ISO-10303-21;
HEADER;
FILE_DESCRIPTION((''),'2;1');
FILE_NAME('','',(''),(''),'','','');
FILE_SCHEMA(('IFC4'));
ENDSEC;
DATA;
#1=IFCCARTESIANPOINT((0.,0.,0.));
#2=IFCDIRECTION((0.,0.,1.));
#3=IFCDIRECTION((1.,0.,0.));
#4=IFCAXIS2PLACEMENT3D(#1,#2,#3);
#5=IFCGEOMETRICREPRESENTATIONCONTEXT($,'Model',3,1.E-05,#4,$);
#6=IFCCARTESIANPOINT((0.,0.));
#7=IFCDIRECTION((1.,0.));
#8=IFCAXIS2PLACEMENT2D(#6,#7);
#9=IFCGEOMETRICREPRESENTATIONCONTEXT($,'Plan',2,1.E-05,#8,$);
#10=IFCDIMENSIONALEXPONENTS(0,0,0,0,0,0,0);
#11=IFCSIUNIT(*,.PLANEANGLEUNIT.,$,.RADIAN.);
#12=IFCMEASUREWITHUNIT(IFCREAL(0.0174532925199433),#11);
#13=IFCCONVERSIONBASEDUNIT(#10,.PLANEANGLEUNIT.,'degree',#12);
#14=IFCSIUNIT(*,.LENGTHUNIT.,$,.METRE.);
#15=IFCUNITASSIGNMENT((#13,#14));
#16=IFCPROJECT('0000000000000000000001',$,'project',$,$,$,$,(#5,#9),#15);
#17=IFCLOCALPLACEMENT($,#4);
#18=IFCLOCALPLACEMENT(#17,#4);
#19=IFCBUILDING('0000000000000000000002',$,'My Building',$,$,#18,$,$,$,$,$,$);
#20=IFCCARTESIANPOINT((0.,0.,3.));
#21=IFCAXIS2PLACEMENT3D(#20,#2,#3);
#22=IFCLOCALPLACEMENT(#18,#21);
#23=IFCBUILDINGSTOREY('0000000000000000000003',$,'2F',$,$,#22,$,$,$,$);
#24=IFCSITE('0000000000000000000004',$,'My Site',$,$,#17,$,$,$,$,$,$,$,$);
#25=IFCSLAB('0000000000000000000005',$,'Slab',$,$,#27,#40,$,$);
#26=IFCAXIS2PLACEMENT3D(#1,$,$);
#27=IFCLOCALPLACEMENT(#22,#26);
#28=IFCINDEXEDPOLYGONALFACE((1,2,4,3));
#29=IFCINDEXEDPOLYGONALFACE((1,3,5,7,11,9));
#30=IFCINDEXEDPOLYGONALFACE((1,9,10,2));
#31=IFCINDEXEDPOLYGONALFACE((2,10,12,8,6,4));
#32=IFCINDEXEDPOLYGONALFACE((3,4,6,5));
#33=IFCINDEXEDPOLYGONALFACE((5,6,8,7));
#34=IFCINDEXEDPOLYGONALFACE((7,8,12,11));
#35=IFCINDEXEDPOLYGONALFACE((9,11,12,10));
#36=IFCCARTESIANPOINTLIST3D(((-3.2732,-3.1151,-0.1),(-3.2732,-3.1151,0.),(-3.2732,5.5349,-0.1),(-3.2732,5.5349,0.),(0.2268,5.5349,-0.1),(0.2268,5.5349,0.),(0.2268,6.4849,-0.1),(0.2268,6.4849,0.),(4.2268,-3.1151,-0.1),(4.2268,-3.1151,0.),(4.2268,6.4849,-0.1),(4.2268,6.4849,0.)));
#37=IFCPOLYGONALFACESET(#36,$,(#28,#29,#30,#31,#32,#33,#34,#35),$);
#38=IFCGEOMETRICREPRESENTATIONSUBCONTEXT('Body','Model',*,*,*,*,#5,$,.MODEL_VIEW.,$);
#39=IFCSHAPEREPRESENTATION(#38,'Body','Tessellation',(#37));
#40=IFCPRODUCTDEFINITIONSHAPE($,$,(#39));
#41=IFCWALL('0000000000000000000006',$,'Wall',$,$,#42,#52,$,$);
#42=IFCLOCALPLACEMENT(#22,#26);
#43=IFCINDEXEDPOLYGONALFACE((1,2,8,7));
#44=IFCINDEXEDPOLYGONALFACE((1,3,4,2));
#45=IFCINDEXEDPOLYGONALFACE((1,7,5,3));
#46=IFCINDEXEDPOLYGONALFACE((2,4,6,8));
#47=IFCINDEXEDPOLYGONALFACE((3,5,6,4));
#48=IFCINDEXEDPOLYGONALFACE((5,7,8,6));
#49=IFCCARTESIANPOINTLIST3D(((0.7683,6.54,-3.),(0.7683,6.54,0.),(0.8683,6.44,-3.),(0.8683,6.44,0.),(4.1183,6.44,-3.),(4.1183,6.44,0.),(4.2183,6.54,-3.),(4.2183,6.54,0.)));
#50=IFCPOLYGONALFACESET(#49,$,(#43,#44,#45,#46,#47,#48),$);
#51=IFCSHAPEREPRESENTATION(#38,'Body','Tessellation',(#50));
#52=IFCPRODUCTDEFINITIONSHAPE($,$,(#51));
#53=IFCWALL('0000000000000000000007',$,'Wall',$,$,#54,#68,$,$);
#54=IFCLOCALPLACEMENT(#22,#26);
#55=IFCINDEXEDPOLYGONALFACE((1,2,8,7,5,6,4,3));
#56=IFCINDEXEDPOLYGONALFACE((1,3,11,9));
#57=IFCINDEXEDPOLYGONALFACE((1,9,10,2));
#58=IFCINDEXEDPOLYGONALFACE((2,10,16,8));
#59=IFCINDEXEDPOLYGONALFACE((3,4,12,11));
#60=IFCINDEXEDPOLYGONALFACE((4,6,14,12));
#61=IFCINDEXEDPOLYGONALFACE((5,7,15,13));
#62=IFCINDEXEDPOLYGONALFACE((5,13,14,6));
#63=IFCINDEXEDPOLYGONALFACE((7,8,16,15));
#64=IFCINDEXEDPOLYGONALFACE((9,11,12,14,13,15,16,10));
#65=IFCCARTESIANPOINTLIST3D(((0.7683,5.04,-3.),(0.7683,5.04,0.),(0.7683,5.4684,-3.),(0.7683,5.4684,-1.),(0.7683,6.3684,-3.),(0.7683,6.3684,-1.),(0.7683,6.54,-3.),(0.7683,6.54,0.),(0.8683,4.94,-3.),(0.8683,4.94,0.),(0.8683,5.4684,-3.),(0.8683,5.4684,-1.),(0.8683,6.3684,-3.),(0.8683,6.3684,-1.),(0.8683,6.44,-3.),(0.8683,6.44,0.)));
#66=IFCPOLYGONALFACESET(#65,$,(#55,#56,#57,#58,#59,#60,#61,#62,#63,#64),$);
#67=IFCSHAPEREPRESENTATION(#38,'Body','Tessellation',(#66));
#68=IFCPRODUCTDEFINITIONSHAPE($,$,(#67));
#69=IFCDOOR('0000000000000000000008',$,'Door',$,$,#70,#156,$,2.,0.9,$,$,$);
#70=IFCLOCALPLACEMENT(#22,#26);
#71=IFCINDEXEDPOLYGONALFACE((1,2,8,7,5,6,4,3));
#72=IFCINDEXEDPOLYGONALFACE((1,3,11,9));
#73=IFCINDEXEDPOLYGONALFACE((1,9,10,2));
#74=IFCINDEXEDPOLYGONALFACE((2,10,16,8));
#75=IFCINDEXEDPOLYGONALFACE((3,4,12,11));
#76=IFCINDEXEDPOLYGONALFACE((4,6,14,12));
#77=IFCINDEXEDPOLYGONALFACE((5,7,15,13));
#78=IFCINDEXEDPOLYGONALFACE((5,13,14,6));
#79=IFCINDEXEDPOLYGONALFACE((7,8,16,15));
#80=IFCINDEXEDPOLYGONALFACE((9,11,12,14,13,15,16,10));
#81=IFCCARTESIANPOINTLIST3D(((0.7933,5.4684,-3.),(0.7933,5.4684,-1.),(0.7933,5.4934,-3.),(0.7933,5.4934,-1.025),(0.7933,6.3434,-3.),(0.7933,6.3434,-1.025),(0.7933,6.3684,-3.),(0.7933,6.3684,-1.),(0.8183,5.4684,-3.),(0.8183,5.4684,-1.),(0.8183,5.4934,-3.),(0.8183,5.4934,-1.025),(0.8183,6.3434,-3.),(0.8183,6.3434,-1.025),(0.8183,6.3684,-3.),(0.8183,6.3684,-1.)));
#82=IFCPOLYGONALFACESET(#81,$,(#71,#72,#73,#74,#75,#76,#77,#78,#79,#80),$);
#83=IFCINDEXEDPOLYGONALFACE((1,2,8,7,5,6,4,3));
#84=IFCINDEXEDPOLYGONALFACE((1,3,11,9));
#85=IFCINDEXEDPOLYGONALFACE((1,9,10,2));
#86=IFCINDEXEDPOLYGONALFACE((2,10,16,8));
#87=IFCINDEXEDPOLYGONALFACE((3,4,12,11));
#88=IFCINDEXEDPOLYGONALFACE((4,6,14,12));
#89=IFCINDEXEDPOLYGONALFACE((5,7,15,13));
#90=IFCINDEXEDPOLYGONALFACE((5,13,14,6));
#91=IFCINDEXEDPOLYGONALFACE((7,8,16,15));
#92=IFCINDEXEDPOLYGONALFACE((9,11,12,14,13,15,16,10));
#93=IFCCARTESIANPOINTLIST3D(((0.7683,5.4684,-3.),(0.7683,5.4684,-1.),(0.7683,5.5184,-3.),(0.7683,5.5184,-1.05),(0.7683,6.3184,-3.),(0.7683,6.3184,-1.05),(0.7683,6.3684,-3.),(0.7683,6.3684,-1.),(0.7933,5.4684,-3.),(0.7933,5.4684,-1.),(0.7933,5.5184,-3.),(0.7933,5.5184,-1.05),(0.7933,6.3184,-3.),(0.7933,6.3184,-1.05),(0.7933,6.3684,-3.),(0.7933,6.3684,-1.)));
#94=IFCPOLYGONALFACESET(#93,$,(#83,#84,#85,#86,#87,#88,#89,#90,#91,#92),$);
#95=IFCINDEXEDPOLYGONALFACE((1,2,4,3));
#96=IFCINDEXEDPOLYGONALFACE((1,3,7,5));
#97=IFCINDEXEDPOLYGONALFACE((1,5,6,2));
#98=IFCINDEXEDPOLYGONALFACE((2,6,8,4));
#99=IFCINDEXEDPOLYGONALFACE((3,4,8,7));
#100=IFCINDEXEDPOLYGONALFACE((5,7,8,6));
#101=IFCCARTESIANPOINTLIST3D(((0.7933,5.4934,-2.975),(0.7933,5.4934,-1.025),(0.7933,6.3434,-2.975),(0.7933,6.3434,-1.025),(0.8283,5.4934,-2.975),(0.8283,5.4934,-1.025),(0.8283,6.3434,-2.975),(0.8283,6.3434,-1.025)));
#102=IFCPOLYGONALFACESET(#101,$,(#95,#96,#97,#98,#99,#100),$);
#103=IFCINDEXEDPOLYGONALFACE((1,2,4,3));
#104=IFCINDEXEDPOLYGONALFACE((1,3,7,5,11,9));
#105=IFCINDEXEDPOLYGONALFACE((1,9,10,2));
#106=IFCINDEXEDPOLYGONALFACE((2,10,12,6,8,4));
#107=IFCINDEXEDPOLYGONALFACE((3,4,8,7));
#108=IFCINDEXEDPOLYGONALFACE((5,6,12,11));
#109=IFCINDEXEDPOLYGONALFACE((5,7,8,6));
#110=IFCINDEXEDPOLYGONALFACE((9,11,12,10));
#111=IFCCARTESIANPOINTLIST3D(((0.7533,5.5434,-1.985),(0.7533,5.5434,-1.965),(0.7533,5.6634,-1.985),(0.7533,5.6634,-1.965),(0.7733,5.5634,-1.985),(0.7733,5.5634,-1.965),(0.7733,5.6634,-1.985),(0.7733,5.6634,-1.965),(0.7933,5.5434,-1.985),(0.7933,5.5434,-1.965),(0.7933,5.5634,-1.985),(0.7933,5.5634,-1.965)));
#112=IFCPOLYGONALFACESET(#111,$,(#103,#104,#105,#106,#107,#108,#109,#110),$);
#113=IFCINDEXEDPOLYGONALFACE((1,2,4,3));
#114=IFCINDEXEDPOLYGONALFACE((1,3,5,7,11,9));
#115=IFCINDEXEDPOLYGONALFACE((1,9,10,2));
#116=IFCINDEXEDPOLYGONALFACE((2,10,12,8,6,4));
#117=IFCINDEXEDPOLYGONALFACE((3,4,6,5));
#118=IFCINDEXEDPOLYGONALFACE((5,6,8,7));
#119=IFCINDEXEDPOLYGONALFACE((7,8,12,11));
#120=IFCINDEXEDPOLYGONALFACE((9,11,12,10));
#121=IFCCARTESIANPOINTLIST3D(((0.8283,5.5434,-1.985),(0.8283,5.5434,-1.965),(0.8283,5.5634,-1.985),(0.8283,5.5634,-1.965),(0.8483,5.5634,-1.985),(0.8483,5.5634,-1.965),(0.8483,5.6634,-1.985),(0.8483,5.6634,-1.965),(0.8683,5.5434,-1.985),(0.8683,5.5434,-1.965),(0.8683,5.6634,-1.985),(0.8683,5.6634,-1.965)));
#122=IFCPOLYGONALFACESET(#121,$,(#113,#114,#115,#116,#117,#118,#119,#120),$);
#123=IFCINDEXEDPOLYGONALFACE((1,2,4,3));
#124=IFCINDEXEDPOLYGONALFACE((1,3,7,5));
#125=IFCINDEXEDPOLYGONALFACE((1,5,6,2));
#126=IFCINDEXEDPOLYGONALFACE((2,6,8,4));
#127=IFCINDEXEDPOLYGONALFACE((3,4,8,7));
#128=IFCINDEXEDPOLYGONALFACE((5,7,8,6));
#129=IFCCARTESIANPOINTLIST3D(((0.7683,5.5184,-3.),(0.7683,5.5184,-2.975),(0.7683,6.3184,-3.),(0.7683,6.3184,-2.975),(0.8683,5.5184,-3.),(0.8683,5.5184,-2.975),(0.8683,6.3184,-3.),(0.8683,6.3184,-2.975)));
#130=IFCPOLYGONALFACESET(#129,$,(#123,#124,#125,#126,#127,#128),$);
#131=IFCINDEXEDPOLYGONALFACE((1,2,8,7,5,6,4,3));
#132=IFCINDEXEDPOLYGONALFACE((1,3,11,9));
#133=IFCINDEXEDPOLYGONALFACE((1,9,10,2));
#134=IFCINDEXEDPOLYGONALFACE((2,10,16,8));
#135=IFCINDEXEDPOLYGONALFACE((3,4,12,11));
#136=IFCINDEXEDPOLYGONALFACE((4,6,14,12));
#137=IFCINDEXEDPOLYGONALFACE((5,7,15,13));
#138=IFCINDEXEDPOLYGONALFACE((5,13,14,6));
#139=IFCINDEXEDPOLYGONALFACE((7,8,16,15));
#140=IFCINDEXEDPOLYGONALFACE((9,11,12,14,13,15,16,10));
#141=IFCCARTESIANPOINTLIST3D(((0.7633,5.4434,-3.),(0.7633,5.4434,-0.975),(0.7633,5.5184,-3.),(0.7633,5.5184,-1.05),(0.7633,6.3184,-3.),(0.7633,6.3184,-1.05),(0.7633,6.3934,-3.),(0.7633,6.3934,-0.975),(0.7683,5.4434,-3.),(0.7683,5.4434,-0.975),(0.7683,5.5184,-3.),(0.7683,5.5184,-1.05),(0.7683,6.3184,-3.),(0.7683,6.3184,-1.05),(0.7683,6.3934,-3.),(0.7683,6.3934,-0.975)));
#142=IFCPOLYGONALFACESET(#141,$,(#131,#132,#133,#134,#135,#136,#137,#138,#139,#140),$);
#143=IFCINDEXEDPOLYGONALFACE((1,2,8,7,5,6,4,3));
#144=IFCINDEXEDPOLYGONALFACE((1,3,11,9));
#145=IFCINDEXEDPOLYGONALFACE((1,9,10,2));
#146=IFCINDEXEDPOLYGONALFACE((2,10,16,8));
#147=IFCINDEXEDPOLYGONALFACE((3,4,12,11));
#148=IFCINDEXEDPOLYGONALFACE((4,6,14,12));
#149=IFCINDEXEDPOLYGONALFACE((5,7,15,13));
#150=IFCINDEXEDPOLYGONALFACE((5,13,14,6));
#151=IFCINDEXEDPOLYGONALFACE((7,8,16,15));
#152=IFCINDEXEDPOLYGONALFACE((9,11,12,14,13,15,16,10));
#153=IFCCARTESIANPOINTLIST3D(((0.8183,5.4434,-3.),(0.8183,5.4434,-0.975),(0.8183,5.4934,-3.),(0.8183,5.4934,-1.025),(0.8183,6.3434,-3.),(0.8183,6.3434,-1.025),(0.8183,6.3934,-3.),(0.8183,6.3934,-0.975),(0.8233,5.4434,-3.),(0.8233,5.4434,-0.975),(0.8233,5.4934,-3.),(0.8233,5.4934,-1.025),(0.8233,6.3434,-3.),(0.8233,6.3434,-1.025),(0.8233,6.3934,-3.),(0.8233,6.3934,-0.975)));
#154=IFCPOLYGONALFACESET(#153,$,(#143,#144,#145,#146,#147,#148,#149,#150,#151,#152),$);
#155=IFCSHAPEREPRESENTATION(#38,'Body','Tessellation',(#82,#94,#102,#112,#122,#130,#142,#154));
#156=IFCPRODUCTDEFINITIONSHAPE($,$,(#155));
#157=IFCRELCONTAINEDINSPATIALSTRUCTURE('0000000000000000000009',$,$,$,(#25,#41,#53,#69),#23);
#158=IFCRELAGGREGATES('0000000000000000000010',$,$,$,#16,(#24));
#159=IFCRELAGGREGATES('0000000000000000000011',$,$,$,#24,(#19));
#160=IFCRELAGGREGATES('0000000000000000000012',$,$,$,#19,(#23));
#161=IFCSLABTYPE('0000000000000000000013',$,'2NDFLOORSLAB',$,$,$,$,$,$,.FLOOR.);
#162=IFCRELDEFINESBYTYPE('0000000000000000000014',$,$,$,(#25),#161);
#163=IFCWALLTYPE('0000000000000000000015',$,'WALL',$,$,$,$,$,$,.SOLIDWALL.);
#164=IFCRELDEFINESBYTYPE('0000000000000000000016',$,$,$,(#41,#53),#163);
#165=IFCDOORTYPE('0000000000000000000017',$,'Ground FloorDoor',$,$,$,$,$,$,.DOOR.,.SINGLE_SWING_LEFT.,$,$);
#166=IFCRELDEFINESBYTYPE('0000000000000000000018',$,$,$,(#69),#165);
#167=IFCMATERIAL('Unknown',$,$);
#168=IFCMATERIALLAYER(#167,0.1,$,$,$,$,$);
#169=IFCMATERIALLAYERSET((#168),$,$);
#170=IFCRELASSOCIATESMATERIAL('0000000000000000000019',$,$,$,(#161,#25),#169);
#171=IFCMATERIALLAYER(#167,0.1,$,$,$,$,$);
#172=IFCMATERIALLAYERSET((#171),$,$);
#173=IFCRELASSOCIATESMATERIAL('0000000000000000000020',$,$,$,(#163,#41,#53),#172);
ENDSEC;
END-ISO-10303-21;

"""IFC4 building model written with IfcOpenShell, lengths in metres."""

from ifc_helpers import new_model, entity, si_unit, converted_unit, frame, origin_with_axes, origin_2d_with_axis, place, context, subcontext, project, spatial, line, indexed_curve, outline, extrude, shape, source, transform, mapped, material, layer, layer_set, layer_usage, type_object, type_shapes, element, fill, save


model = new_model("IFC4")

# Units and contexts
model_context = context("Model", 3, precision=1e-05, world=origin_with_axes())
plan_context = context("Plan", 2, precision=1e-05, world=origin_2d_with_axis())
body_context_1 = subcontext(model_context, "Body", "Model", "MODEL_VIEW")
body_context_2 = subcontext(plan_context, "Body", "Plan", "PLAN_VIEW")
ifc_project = project(units=[converted_unit("PLANEANGLEUNIT", "degree", entity("IfcReal", 0.0174532925199433), si_unit("PLANEANGLEUNIT", "RADIAN"), dimensions=[0, 0, 0, 0, 0, 0, 0]), si_unit("LENGTHUNIT", "METRE")], contexts=[model_context, plan_context])

# Site, building, storey
site_placement = place(None, origin_with_axes())
site = spatial("IfcSite", under=ifc_project, at=site_placement, Name="My Site")
building_placement = place(site_placement, origin_with_axes())
building = spatial("IfcBuilding", under=site, at=building_placement, Name="My Building")
storey_placement = place(building_placement, frame((0.0, 0.0, 3.0), z_axis=(0.0, 0.0, 1.0), x_axis=(1.0, 0.0, 0.0)))
storey = spatial("IfcBuildingStorey", under=building, at=storey_placement, Name="2F")

# Slab
ifc_material = material(Name="Unknown")
ifc_layer_1 = layer(ifc_material, 0.1)
ifc_layer_set_1 = layer_set([ifc_layer_1])
ifc_layer_usage_1 = layer_usage(ifc_layer_set_1, "AXIS3", "POSITIVE", -0.1)
slab_type = type_object("IfcSlabType", Name="2NDFLOORSLAB", PredefinedType="FLOOR", material=ifc_layer_set_1)
slab_placement = place(storey_placement, frame((-3.2732, 5.5349, 0.0), z_axis=(0.0, 0.0, 1.0), x_axis=(1.0, 0.0, 0.0)))
element("IfcSlab", 1, at=slab_placement, inside=storey, type_object=slab_type, material=ifc_layer_usage_1, Name="Slab", context=body_context_1, shape_type="SweptSolid", body=[
    extrude(outline(indexed_curve([(0.0, 0.0), (3.5, 0.0), (3.5, 0.95), (7.5, 0.95), (7.5, -8.65), (0.0, -8.65), (0.0, 0.0)])), frame((0.0, 0.0, -0.1), z_axis=(0.0, 0.0, 1.0), x_axis=(1.0, 0.0, 0.0)), (0.0, 0.0, 1.0), 0.1),
])

# Wall
ifc_layer_2 = layer(ifc_material, 0.1)
ifc_layer_set_2 = layer_set([ifc_layer_2])
ifc_layer_usage_2 = layer_usage(ifc_layer_set_2, "AXIS2", "POSITIVE", 0.0)
wall_type_1 = type_object("IfcWallType", Name="WALL", PredefinedType="SOLIDWALL", material=ifc_layer_set_2)
wall_1_placement = place(storey_placement, frame((4.2183, 6.54, -3.0), z_axis=(0.0, 0.0, 1.0), x_axis=(-1.0, 0.0, 0.0)))
element("IfcWall", 2, at=wall_1_placement, inside=storey, type_object=wall_type_1, material=ifc_layer_usage_2, Name="Wall", context=body_context_1, shape_type="SweptSolid", body=[
    extrude(outline(indexed_curve([(0.0, 0.0), (0.1, 0.1), (3.35, 0.1), (3.45, 0.0)], segments=[line(1, 2, 3, 4, 1)])), origin_with_axes(), (0.0, 0.0, 1.0), 3.0),
])

# Wall, opening, door
ifc_layer_usage_3 = layer_usage(ifc_layer_set_2, "AXIS2", "POSITIVE", 0.0)
wall_2_placement = place(storey_placement, frame((0.7683, 6.54, -3.0), z_axis=(0.0, 0.0, 1.0), x_axis=(0.0, -1.0, 0.0)))
wall_2 = element("IfcWall", 3, at=wall_2_placement, inside=storey, type_object=wall_type_1, material=ifc_layer_usage_3, Name="Wall", context=body_context_1, shape_type="SweptSolid", body=[
    extrude(outline(indexed_curve([(0.0, 0.0), (0.1, 0.1), (1.6, 0.1), (1.5, 0.0)], segments=[line(1, 2, 3, 4, 1)])), origin_with_axes(), (0.0, 0.0, 1.0), 3.0),
])
shared_shape_1 = source(origin_with_axes(), body_context_1, "Body", "SweptSolid", [
    extrude(outline(indexed_curve([(0.0, 0.0), (0.9, 0.0), (0.9, 2.0), (0.0, 2.0)], segments=[line(1, 2, 3, 4, 1)])), frame((0.0, -0.6, 0.0), z_axis=(0.0, -1.0, 0.0), x_axis=(1.0, 0.0, 0.0)), (0.0, 0.0, -1.0), 1.2),
])
opening_1_placement = place(wall_2_placement, frame((0.1715, 0.0, 0.0), z_axis=(0.0, 0.0, 1.0), x_axis=(1.0, 0.0, 0.0)))
opening_1 = element("IfcOpeningElement", 4, at=opening_1_placement, cuts=wall_2, PredefinedType="OPENING", context=body_context_1, shape_type="MappedRepresentation", body=[
    mapped(shared_shape_1, transform((0.0, 0.0, 0.0), x_axis=(1.0, 0.0, 0.0), y_axis=(0.0, 1.0, 0.0), z_axis=(0.0, 0.0, 1.0), scale=1.0)),
])
door_type_1 = type_object("IfcDoorType", Name="Ground FloorDoor", OperationType="SINGLE_SWING_LEFT", PredefinedType="DOOR")
shared_shape_2 = source(origin_with_axes(), body_context_1, "Body", "SweptSolid", [
    extrude(outline(indexed_curve([(0.0, 0.0), (0.0, 2.0), (0.9, 2.0), (0.9, 0.0), (0.875, 0.0), (0.875, 1.975), (0.025, 1.975), (0.025, 0.0)], segments=[line(1, 2, 3, 4, 5, 6, 7, 8, 1)])), frame((0.0, 0.025, 0.0), z_axis=(0.0, -1.0, 0.0), x_axis=(1.0, 0.0, 0.0)), (0.0, 0.0, -1.0), 0.025),
    extrude(outline(indexed_curve([(0.0, 0.0), (0.0, 2.0), (0.9, 2.0), (0.9, 0.0), (0.85, 0.0), (0.85, 1.95), (0.05, 1.95), (0.05, 0.0)], segments=[line(1, 2, 3, 4, 5, 6, 7, 8, 1)])), frame((0.0, 0.0, 0.0), z_axis=(0.0, -1.0, 0.0), x_axis=(1.0, 0.0, 0.0)), (0.0, 0.0, -1.0), 0.025),
    extrude(outline(indexed_curve([(0.0, 0.0), (0.85, 0.0), (0.85, 0.035), (0.0, 0.035)], segments=[line(1, 2, 3, 4, 1)])), frame((0.025, 0.025, 0.025), z_axis=(0.0, 0.0, 1.0), x_axis=(1.0, 0.0, 0.0)), (0.0, 0.0, 1.0), 1.95),
    extrude(outline(indexed_curve([(0.0, 0.0), (0.0, -0.04), (-0.12, -0.04), (-0.12, -0.02), (-0.02, -0.02), (-0.02, 0.0)], segments=[line(1, 2, 3, 4, 5, 6, 1)])), frame((0.825, 0.025, 1.015), z_axis=(0.0, 0.0, 1.0), x_axis=(1.0, 0.0, 0.0)), (0.0, 0.0, 1.0), 0.02),
    extrude(outline(indexed_curve([(0.0, 0.0), (0.0, 0.04), (-0.12, 0.04), (-0.12, 0.02), (-0.02, 0.02), (-0.02, 0.0)], segments=[line(1, 2, 3, 4, 5, 6, 1)])), frame((0.825, 0.06, 1.015), z_axis=(0.0, 0.0, 1.0), x_axis=(1.0, 0.0, 0.0)), (0.0, 0.0, 1.0), 0.02),
    extrude(outline(indexed_curve([(0.0, 0.0), (0.8, 0.0), (0.8, 0.1), (0.0, 0.1)], segments=[line(1, 2, 3, 4, 1)])), frame((0.05, 0.0, 0.0), z_axis=(0.0, 0.0, 1.0), x_axis=(1.0, 0.0, 0.0)), (0.0, 0.0, 1.0), 0.025),
    extrude(outline(indexed_curve([(0.0, 0.0), (0.0, 2.025), (0.95, 2.025), (0.95, 0.0), (0.875, 0.0), (0.875, 1.95), (0.075, 1.95), (0.075, 0.0)], segments=[line(1, 2, 3, 4, 5, 6, 7, 8, 1)])), frame((-0.025, -0.005, 0.0), z_axis=(0.0, -1.0, 0.0), x_axis=(1.0, 0.0, 0.0)), (0.0, 0.0, -1.0), 0.005),
    extrude(outline(indexed_curve([(0.0, 0.0), (0.0, 2.025), (0.95, 2.025), (0.95, 0.0), (0.9, 0.0), (0.9, 1.975), (0.05, 1.975), (0.05, 0.0)], segments=[line(1, 2, 3, 4, 5, 6, 7, 8, 1)])), frame((-0.025, 0.05, 0.0), z_axis=(0.0, -1.0, 0.0), x_axis=(1.0, 0.0, 0.0)), (0.0, 0.0, -1.0), 0.005),
])
shared_shape_3 = source(origin_with_axes(), body_context_2, "Body", "Curve2D", [
    entity("IfcIndexedPolyCurve", entity("IfcCartesianPointList2D", [[0.0, 0.0], [0.0, 0.05], [0.025, 0.05], [0.025, 0.025], [0.05, 0.025], [0.05, 0.0]]), [entity("IfcLineIndex", [1, 2, 3, 4, 5, 6, 1])]),
    entity("IfcIndexedPolyCurve", entity("IfcCartesianPointList2D", [[0.9, 0.0], [0.9, 0.05], [0.875, 0.05], [0.875, 0.025], [0.85, 0.025], [0.85, 0.0]]), [entity("IfcLineIndex", [1, 2, 3, 4, 5, 6, 1])]),
    entity("IfcTrimmedCurve", entity("IfcEllipse", entity("IfcAxis2Placement2D", entity("IfcCartesianPoint", [0.06, 0.05]), entity("IfcDirection", [1.0, 0.0])), 0.815, 0.85), [entity("IfcCartesianPoint", [0.875, 0.05])], [entity("IfcCartesianPoint", [0.06, 0.9])], True, "CARTESIAN"),
    entity("IfcIndexedPolyCurve", entity("IfcCartesianPointList2D", [[0.025, 0.05], [0.06, 0.05], [0.06, 0.9], [0.025, 0.9]]), [entity("IfcLineIndex", [1, 2, 3, 4, 1])]),
])
type_shapes(door_type_1, [shared_shape_2, shared_shape_3])
door_1_placement = place(opening_1_placement, frame((0.0, 0.0, 0.0), z_axis=(0.0, 0.0, 1.0), x_axis=(1.0, 0.0, 0.0)))
door_1 = element("IfcDoor", 5, at=door_1_placement, inside=storey, type_object=door_type_1, Name="Door", OverallHeight=2.0, OverallWidth=0.9, shapes=[
    shape(body_context_1, "Body", "MappedRepresentation", [mapped(shared_shape_2, transform((0.0, 0.0, 0.0), x_axis=(1.0, 0.0, 0.0), y_axis=(0.0, 1.0, 0.0), z_axis=(0.0, 0.0, 1.0), scale=1.0))]),
    shape(body_context_2, "Body", "MappedRepresentation", [mapped(shared_shape_3, transform((0.0, 0.0, 0.0), x_axis=(1.0, 0.0, 0.0), y_axis=(0.0, 1.0, 0.0), z_axis=(0.0, 0.0, 1.0), scale=1.0))]),
])
fill(opening_1, door_1)

save(model, "model.ifc")
